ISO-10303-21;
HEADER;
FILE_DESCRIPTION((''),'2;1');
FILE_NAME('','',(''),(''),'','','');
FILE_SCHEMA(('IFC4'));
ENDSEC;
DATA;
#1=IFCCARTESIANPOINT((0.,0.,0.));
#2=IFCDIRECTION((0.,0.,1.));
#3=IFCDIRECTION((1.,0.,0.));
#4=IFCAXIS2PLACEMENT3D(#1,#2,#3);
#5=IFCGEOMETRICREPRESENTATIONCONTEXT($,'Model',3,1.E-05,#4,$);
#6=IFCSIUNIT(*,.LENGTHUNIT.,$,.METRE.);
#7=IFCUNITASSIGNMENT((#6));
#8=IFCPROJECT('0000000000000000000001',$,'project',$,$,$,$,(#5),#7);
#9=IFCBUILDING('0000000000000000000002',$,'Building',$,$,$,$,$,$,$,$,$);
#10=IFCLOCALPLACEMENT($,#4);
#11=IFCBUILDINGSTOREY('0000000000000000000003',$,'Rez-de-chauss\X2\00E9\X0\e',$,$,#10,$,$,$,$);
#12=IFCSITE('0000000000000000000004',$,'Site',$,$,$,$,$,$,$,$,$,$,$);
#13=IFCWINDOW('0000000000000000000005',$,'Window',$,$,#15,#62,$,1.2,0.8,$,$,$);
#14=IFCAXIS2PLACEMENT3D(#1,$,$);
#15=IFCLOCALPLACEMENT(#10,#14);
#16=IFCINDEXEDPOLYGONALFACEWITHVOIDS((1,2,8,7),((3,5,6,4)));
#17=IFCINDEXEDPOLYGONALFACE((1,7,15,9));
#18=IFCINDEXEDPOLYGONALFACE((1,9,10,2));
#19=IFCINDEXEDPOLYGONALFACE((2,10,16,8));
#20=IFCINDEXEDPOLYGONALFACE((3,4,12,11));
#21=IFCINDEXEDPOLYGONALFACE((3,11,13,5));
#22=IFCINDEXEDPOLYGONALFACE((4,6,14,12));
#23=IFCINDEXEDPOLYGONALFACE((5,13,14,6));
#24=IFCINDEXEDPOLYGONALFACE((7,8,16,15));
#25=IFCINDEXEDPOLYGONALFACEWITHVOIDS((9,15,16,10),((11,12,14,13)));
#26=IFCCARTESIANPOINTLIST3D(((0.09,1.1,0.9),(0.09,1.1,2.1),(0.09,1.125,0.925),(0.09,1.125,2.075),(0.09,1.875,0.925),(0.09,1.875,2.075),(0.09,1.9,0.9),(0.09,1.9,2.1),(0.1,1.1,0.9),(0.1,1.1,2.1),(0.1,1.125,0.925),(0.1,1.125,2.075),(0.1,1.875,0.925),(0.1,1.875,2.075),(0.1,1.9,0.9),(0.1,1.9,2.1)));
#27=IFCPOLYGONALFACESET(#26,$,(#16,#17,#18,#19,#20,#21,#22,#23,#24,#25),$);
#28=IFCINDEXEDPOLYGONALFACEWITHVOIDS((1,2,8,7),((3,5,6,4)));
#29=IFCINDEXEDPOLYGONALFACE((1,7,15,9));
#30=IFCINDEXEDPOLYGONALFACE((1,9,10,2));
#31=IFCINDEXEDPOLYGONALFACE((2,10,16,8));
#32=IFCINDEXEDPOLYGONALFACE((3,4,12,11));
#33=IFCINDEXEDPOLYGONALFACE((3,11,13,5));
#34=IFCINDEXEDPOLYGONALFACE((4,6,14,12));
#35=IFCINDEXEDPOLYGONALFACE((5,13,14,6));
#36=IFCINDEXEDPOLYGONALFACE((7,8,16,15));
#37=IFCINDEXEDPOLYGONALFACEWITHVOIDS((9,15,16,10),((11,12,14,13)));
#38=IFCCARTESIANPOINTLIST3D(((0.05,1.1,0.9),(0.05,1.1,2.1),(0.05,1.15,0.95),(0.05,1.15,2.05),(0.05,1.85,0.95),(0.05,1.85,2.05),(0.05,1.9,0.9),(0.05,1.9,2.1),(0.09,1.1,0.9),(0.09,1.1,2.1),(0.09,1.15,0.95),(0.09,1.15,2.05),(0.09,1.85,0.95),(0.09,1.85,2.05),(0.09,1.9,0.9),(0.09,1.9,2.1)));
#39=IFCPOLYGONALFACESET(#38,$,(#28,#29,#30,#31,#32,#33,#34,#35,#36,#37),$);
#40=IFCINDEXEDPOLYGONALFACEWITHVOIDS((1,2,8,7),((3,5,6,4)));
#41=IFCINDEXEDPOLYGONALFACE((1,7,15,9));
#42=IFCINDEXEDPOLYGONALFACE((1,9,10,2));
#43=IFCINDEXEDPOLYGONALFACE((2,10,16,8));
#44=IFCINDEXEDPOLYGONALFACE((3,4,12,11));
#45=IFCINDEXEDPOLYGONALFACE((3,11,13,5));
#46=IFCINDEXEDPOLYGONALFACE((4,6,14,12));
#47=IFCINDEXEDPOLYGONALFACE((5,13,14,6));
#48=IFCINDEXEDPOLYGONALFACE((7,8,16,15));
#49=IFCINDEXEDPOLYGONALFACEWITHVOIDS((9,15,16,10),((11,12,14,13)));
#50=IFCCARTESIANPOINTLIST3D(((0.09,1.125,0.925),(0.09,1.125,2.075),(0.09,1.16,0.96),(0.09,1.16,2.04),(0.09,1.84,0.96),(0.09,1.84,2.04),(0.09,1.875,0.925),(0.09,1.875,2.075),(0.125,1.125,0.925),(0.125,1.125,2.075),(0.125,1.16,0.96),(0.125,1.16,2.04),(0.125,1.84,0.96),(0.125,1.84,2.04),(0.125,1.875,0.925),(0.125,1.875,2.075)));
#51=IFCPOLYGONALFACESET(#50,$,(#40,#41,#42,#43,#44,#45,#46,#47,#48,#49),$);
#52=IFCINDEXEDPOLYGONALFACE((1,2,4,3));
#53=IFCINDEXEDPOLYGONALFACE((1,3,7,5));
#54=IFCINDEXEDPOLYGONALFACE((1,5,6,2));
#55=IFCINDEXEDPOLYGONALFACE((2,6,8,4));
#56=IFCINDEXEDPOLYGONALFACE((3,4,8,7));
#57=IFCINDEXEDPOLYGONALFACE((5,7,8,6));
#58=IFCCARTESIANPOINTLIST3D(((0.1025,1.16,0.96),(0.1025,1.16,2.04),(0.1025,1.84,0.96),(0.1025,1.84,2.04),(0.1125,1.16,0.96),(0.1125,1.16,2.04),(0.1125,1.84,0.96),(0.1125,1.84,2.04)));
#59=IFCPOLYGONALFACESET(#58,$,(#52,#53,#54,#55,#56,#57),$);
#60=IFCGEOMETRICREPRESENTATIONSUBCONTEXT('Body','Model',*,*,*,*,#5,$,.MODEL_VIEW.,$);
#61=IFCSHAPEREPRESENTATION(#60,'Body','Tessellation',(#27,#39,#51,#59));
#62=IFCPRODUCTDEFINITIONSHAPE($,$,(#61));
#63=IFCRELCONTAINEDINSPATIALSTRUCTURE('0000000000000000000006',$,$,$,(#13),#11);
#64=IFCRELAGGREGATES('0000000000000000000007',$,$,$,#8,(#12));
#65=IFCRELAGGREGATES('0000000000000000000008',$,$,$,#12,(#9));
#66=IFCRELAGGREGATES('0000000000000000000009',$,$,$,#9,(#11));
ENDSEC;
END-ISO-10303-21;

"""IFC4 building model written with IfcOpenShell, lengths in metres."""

from ifc_helpers import new_model, si_unit, frame, origin_with_axes, place, context, subcontext, project, spatial, line, indexed_curve, outline, extrude, element, save


model = new_model("IFC4")

# Units and contexts
model_context = context("Model", 3, precision=1e-05, world=origin_with_axes())
body_context = subcontext(model_context, "Body", "Model", "MODEL_VIEW")
ifc_project = project(units=[si_unit("LENGTHUNIT", "METRE")], contexts=[model_context])

# Site, building, storey
site = spatial("IfcSite", under=ifc_project, Name="Site")
building = spatial("IfcBuilding", under=site, Name="Building")
storey_placement = place(None, origin_with_axes())
storey = spatial("IfcBuildingStorey", under=building, at=storey_placement, Name="Rez-de-chaussée")

# Window
window_1_placement = place(storey_placement, frame((0.0, 1.9, 0.9), z_axis=(0.0, 0.0, 1.0), x_axis=(0.0, -1.0, 0.0)))
element("IfcWindow", 1, at=window_1_placement, inside=storey, Name="Window", OverallHeight=1.2, OverallWidth=0.8, context=body_context, shape_type="SweptSolid", body=[
    extrude(outline(indexed_curve([(0.0, 0.0), (0.8, 0.0), (0.8, 1.2), (0.0, 1.2)], segments=[line(1, 2, 3, 4, 1)]), holes=[indexed_curve([(0.025, 0.025), (0.775, 0.025), (0.775, 1.175), (0.025, 1.175)], segments=[line(1, 2, 3, 4, 1)])]), frame((0.0, 0.09, 0.0), z_axis=(0.0, -1.0, 0.0), x_axis=(1.0, 0.0, 0.0)), (0.0, 0.0, -1.0), 0.01),
    extrude(outline(indexed_curve([(0.0, 0.0), (0.8, 0.0), (0.8, 1.2), (0.0, 1.2)], segments=[line(1, 2, 3, 4, 1)]), holes=[indexed_curve([(0.05, 0.05), (0.75, 0.05), (0.75, 1.15), (0.05, 1.15)], segments=[line(1, 2, 3, 4, 1)])]), frame((0.0, 0.05, 0.0), z_axis=(0.0, -1.0, 0.0), x_axis=(1.0, 0.0, 0.0)), (0.0, 0.0, -1.0), 0.04),
    extrude(outline(indexed_curve([(0.0, 0.0), (0.75, 0.0), (0.75, 1.15), (0.0, 1.15)], segments=[line(1, 2, 3, 4, 1)]), holes=[indexed_curve([(0.035, 0.035), (0.715, 0.035), (0.715, 1.115), (0.035, 1.115)], segments=[line(1, 2, 3, 4, 1)])]), frame((0.025, 0.09, 0.025), z_axis=(0.0, -1.0, 0.0), x_axis=(1.0, 0.0, 0.0)), (0.0, 0.0, -1.0), 0.035),
    extrude(outline(indexed_curve([(0.035, 0.035), (0.715, 0.035), (0.715, 1.115), (0.035, 1.115)], segments=[line(1, 2, 3, 4, 1)])), frame((0.025, 0.1025, 0.025), z_axis=(0.0, -1.0, 0.0), x_axis=(1.0, 0.0, 0.0)), (0.0, 0.0, -1.0), 0.01),
])

save(model, "model.ifc")
